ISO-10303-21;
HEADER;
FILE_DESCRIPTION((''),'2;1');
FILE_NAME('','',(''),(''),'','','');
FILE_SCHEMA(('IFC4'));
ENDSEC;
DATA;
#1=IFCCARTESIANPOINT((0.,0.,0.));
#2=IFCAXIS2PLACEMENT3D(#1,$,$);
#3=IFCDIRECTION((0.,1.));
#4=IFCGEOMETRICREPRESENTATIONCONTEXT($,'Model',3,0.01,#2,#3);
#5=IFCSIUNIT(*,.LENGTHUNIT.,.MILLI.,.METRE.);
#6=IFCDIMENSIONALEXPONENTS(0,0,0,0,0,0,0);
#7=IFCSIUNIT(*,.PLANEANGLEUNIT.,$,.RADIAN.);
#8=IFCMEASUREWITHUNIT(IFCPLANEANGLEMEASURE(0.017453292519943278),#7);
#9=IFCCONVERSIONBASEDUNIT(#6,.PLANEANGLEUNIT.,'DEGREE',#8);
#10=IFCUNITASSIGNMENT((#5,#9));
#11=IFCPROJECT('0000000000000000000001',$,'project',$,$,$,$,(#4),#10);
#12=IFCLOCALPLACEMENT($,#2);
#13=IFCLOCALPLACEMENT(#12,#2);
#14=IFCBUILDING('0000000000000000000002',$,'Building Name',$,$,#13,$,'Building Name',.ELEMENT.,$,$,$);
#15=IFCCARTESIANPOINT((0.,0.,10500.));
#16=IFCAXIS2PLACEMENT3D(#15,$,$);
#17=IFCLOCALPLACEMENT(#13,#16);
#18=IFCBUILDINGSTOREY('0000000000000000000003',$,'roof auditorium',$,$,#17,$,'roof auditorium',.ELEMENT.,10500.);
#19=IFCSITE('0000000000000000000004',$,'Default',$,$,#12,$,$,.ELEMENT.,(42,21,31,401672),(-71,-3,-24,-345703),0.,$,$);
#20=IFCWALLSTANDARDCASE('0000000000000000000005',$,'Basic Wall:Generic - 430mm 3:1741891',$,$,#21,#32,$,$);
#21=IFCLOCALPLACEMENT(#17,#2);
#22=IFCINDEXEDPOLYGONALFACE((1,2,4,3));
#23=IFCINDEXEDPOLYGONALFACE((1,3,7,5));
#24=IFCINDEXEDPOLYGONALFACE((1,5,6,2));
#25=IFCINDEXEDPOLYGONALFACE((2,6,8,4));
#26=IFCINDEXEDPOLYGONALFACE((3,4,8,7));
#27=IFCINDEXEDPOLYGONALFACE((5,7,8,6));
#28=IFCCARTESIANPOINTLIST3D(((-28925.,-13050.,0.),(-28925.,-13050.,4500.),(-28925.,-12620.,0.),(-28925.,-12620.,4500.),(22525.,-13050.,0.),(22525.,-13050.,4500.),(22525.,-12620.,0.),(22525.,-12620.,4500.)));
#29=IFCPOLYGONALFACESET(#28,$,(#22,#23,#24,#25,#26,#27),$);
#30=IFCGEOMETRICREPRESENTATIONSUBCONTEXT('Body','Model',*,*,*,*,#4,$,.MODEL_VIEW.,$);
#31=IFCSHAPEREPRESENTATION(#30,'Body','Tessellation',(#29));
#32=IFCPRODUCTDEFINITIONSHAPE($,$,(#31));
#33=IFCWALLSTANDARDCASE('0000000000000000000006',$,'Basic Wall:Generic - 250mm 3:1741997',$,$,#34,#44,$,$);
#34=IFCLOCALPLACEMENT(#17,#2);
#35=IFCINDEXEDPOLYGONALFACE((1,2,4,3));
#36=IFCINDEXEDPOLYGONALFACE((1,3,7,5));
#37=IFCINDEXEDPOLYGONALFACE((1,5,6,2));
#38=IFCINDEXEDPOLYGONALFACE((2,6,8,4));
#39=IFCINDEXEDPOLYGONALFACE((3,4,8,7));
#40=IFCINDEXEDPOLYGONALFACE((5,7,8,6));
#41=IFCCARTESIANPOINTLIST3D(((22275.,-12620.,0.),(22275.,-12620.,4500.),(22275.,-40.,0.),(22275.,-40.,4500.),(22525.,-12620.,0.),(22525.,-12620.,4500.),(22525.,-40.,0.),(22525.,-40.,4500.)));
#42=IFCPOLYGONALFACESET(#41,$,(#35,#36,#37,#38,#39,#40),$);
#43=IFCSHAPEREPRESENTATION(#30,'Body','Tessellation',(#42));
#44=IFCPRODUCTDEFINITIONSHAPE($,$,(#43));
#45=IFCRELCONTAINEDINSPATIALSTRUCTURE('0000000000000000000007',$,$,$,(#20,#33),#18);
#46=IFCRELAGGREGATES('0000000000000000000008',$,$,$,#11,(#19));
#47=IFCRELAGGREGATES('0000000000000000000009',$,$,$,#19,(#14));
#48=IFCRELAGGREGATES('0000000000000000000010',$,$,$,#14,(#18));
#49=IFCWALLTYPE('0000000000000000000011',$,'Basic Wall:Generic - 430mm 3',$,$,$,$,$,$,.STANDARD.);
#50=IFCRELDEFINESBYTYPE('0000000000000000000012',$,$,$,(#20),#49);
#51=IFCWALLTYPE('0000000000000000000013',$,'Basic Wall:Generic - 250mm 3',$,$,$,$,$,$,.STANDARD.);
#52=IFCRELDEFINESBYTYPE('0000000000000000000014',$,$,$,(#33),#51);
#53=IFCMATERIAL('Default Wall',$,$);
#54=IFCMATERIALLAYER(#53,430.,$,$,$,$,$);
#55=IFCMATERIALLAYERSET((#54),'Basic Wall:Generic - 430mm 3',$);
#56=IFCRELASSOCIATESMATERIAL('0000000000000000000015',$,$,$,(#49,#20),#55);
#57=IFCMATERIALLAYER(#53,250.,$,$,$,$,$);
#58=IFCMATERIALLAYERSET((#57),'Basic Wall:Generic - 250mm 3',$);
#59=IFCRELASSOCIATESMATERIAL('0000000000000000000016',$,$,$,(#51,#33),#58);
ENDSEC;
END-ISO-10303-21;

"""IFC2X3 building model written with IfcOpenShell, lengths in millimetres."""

from ifc_helpers import new_model, entity, si_unit, converted_unit, direction, frame, frame_2d, origin, place, context, subcontext, project, spatial, rectangle, extrude, material, layer, layer_set, layer_usage, type_object, element, save


model = new_model("IFC2X3")

# Units and contexts
model_context = context("Model", 3, precision=0.01, world=origin(), true_north=direction((0.0, 1.0)))
body_context = subcontext(model_context, "Body", "Model", "MODEL_VIEW")
ifc_project = project(units=[si_unit("LENGTHUNIT", "METRE", prefix="MILLI"), converted_unit("PLANEANGLEUNIT", "DEGREE", entity("IfcPlaneAngleMeasure", 0.017453292519943278), si_unit("PLANEANGLEUNIT", "RADIAN"), dimensions=[0, 0, 0, 0, 0, 0, 0])], contexts=[model_context])

# Site, building, storey
site_placement = place(None, origin())
site = spatial("IfcSite", under=ifc_project, at=site_placement, Name="Default", CompositionType="ELEMENT", RefLatitude=(42, 21, 31, 401672), RefLongitude=(-71, -3, -24, -345703), RefElevation=0.0)
building_placement = place(site_placement, origin())
building = spatial("IfcBuilding", under=site, at=building_placement, Name="Building Name", LongName="Building Name", CompositionType="ELEMENT")
storey_placement = place(building_placement, frame((0.0, 0.0, 10500.0)))
storey = spatial("IfcBuildingStorey", under=building, at=storey_placement, Name="roof auditorium", LongName="roof auditorium", CompositionType="ELEMENT", Elevation=10500.0)

# Walls
ifc_material = material(Name="Default Wall")
ifc_layer_1 = layer(ifc_material, 430.0)
ifc_layer_set_1 = layer_set([ifc_layer_1], Name="Basic Wall:Generic - 430mm 3")
ifc_layer_usage_1 = layer_usage(ifc_layer_set_1, "AXIS2", "NEGATIVE", 215.0)
wall_type_1 = type_object("IfcWallType", Name="Basic Wall:Generic - 430mm 3", PredefinedType="STANDARD", material=ifc_layer_set_1)
wall_1_placement = place(storey_placement, frame((-28925.0, -12835.0, 0.0)))
element("IfcWallStandardCase", 1, at=wall_1_placement, inside=storey, type_object=wall_type_1, material=ifc_layer_usage_1, Name="Basic Wall:Generic - 430mm 3:1741891", context=body_context, shape_type="SweptSolid", body=[
    extrude(rectangle(XDim=51450.0, YDim=430.0, at=frame_2d((25725.0, 0.0), x_axis=(-1.0, 0.0))), origin(), (0.0, 0.0, 1.0), 4500.0),
])
ifc_layer_2 = layer(ifc_material, 250.0)
ifc_layer_set_2 = layer_set([ifc_layer_2], Name="Basic Wall:Generic - 250mm 3")
ifc_layer_usage_2 = layer_usage(ifc_layer_set_2, "AXIS2", "NEGATIVE", 125.0)
wall_type_2 = type_object("IfcWallType", Name="Basic Wall:Generic - 250mm 3", PredefinedType="STANDARD", material=ifc_layer_set_2)
wall_2_placement = place(storey_placement, frame((22400.0, -12620.0, 0.0), z_axis=(0.0, 0.0, 1.0), x_axis=(0.0, 1.0, 0.0)))
element("IfcWallStandardCase", 2, at=wall_2_placement, inside=storey, type_object=wall_type_2, material=ifc_layer_usage_2, Name="Basic Wall:Generic - 250mm 3:1741997", context=body_context, shape_type="SweptSolid", body=[
    extrude(rectangle(XDim=12580.0, YDim=250.0, at=frame_2d((6290.0, 0.0), x_axis=(-1.0, 0.0))), origin(), (0.0, 0.0, 1.0), 4500.0),
])

save(model, "model.ifc")
